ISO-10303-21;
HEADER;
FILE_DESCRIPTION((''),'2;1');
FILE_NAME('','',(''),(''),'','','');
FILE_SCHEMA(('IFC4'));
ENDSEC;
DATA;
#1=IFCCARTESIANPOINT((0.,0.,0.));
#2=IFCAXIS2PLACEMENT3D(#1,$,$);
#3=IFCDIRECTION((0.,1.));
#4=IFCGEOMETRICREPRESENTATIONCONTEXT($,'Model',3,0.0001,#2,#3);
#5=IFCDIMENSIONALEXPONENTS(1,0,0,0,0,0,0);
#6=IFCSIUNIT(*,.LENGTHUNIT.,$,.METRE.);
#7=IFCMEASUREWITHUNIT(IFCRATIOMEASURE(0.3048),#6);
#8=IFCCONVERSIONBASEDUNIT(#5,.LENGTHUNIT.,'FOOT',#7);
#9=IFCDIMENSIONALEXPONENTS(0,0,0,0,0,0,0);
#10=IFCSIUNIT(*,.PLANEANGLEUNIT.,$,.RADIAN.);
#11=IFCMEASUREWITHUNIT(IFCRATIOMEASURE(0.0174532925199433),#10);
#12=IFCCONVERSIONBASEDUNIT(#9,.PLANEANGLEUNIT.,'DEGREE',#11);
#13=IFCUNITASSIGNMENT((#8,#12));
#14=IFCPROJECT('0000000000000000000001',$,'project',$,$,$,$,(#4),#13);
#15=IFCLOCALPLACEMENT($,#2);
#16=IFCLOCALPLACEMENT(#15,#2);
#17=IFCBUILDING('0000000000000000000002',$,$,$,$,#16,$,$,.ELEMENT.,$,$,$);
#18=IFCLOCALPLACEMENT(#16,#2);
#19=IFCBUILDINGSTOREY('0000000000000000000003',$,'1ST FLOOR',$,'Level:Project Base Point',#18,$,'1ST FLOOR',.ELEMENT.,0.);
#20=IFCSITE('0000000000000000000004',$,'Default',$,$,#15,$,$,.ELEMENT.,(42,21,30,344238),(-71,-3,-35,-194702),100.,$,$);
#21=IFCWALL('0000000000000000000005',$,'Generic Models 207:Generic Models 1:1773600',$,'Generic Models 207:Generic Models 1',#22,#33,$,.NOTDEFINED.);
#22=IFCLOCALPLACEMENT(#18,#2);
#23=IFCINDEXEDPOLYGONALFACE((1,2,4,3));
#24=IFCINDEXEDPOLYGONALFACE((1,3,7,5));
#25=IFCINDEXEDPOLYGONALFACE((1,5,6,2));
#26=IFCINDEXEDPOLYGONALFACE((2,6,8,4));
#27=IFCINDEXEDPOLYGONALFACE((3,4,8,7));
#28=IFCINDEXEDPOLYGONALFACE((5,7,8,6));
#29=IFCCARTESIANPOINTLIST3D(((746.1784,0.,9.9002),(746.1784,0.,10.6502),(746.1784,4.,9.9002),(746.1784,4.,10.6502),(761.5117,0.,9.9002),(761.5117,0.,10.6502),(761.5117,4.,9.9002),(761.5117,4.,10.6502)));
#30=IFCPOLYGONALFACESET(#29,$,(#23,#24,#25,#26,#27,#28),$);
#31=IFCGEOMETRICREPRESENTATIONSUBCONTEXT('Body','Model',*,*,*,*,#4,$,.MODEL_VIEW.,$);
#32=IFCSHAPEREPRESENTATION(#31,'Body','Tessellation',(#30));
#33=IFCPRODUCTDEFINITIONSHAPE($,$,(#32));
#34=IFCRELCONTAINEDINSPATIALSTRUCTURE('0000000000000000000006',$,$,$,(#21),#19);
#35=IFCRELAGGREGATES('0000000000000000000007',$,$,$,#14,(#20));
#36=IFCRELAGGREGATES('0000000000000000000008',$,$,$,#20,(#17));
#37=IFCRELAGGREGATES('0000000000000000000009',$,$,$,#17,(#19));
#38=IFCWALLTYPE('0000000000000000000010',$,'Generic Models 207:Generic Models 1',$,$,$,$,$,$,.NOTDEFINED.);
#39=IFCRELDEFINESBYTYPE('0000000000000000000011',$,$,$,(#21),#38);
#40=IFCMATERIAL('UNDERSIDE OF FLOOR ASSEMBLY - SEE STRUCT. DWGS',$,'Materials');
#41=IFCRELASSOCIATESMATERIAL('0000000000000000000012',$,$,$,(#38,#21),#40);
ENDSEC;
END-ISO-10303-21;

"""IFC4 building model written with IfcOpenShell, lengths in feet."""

from ifc_helpers import new_model, entity, si_unit, converted_unit, direction, frame, frame_2d, origin, place, context, subcontext, project, spatial, rectangle, extrude, material, type_object, element, save


model = new_model("IFC4")

# Units and contexts
model_context = context("Model", 3, precision=0.0001, world=origin(), true_north=direction((0.0, 1.0)))
body_context = subcontext(model_context, "Body", "Model", "MODEL_VIEW")
ifc_project = project(units=[converted_unit("LENGTHUNIT", "FOOT", entity("IfcRatioMeasure", 0.3048), si_unit("LENGTHUNIT", "METRE"), dimensions=[1, 0, 0, 0, 0, 0, 0]), converted_unit("PLANEANGLEUNIT", "DEGREE", entity("IfcRatioMeasure", 0.0174532925199433), si_unit("PLANEANGLEUNIT", "RADIAN"), dimensions=[0, 0, 0, 0, 0, 0, 0])], contexts=[model_context])

# Site, building, storey
site_placement = place(None, origin())
site = spatial("IfcSite", under=ifc_project, at=site_placement, Name="Default", CompositionType="ELEMENT", RefLatitude=(42, 21, 30, 344238), RefLongitude=(-71, -3, -35, -194702), RefElevation=100.0)
building_placement = place(site_placement, origin())
building = spatial("IfcBuilding", under=site, at=building_placement, CompositionType="ELEMENT")
storey_placement = place(building_placement, origin())
storey = spatial("IfcBuildingStorey", under=building, at=storey_placement, Name="1ST FLOOR", ObjectType="Level:Project Base Point", LongName="1ST FLOOR", CompositionType="ELEMENT", Elevation=0.0)

# Wall
ifc_material_1 = material(Name="UNDERSIDE OF FLOOR ASSEMBLY - SEE STRUCT. DWGS", Category="Materials")
wall_type = type_object("IfcWallType", Name="Generic Models 207:Generic Models 1", PredefinedType="NOTDEFINED", material=ifc_material_1)
wall_placement = place(storey_placement, frame((746.1784, 0.0, 9.9002)))
element("IfcWall", 1, at=wall_placement, inside=storey, type_object=wall_type, material=ifc_material_1, Name="Generic Models 207:Generic Models 1:1773600", ObjectType="Generic Models 207:Generic Models 1", PredefinedType="NOTDEFINED", context=body_context, shape_type="SweptSolid", body=[
    extrude(rectangle(XDim=4.0, YDim=15.3333, at=frame_2d((0.0, 0.0), x_axis=(1.0, 0.0))), frame((7.6667, 2.0, 0.0), z_axis=(0.0, 0.0, 1.0), x_axis=(0.0, 1.0, 0.0)), (0.0, 0.0, 1.0), 0.75),
])

save(model, "model.ifc")
